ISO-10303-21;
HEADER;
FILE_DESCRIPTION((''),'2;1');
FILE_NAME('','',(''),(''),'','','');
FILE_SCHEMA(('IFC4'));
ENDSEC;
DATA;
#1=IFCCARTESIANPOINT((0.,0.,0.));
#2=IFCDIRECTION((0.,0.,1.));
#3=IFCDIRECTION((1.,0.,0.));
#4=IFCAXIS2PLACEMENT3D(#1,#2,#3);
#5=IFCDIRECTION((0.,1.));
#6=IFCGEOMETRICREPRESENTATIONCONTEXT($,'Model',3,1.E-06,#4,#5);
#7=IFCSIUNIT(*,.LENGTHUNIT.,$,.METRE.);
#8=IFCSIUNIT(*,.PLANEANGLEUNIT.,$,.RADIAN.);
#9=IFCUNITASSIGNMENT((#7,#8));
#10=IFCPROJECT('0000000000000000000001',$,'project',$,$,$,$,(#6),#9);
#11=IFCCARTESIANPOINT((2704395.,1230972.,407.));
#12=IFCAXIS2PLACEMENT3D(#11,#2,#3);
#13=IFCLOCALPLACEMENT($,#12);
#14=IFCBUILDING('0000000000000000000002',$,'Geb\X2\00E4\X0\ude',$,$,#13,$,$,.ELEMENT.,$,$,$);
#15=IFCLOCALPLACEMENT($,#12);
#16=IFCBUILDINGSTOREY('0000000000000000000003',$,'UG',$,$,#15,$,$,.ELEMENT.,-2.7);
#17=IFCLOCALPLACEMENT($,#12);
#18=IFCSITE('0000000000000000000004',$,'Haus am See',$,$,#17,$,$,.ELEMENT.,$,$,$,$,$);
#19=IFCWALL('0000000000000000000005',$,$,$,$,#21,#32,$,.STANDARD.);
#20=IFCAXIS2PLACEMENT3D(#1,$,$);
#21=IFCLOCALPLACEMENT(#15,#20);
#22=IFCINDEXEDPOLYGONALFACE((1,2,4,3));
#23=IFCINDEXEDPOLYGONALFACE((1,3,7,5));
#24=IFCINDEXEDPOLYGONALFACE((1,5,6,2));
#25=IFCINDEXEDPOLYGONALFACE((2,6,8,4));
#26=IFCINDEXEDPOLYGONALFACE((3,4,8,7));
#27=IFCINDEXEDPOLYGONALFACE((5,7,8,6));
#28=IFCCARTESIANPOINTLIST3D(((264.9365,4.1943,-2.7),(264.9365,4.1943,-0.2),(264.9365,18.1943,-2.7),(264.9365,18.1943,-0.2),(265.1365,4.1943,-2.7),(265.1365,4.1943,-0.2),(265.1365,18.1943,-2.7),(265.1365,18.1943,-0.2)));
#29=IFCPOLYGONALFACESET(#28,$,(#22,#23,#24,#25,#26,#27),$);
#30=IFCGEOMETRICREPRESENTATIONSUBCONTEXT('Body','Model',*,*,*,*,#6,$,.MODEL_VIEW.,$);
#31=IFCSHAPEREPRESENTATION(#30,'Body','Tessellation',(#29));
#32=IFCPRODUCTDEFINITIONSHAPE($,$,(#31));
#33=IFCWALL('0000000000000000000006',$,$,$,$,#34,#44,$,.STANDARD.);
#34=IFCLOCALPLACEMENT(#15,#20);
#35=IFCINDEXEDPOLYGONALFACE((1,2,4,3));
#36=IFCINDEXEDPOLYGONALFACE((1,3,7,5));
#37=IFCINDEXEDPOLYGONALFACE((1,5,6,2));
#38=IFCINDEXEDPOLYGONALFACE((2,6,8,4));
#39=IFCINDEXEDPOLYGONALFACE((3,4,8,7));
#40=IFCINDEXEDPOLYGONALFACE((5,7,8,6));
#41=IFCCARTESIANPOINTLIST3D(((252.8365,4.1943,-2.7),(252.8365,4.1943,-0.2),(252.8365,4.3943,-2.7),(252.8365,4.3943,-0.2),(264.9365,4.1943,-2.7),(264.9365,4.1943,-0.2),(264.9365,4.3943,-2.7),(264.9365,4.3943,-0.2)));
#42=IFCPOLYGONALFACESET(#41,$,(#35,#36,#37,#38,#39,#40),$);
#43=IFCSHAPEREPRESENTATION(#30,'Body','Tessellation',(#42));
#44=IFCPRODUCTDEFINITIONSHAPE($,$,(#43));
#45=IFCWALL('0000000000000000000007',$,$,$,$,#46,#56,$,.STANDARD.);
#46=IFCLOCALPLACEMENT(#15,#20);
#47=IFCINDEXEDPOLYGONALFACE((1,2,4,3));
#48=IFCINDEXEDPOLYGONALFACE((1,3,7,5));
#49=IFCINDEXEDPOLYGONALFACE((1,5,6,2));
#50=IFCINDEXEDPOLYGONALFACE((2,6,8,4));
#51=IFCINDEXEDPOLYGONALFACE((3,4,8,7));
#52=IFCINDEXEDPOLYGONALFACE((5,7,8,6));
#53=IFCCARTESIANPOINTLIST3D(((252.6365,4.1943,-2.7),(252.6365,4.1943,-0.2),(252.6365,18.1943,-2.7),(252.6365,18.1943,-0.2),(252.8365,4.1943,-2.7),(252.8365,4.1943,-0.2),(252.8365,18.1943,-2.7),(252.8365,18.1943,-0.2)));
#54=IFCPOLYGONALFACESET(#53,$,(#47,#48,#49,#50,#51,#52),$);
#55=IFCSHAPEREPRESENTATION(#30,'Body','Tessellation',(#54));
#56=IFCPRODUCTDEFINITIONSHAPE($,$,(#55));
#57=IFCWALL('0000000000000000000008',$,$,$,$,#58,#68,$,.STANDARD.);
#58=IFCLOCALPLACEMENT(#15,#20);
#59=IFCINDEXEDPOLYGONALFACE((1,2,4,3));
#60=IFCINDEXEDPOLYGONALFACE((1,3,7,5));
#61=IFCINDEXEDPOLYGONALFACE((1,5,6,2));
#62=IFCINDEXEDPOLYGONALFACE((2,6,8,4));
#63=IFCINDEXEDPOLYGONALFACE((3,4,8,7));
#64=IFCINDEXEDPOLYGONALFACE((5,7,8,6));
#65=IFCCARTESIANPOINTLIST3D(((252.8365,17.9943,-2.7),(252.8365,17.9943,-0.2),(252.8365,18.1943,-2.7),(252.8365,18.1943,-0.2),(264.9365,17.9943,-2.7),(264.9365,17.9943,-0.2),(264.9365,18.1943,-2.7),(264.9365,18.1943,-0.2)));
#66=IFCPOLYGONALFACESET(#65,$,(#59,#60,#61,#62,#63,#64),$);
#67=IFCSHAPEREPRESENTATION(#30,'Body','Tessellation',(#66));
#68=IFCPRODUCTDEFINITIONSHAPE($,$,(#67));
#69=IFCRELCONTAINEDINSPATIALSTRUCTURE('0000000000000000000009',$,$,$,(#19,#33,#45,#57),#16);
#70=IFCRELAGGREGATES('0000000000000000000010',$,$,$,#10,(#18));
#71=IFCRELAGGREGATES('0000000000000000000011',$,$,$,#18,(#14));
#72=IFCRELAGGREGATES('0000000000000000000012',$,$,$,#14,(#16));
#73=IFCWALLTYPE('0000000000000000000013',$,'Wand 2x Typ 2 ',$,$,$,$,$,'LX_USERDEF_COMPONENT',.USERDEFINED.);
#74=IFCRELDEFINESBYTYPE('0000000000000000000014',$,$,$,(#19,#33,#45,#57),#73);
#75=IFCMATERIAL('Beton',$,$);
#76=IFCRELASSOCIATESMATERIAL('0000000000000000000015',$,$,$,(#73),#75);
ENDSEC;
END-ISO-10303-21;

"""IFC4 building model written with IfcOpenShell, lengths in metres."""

from ifc_helpers import new_model, si_unit, direction, frame, origin_with_axes, place, context, subcontext, project, spatial, polyline, outline, extrude, material, type_object, element, save


model = new_model("IFC4")

# Units and contexts
model_context = context("Model", 3, precision=1e-06, world=origin_with_axes(), true_north=direction((0.0, 1.0)))
body_context = subcontext(model_context, "Body", "Model", "MODEL_VIEW")
ifc_project = project(units=[si_unit("LENGTHUNIT", "METRE"), si_unit("PLANEANGLEUNIT", "RADIAN")], contexts=[model_context])

# Site, building, storey
site_placement = place(None, frame((2704395.0, 1230972.0, 407.0), z_axis=(0.0, 0.0, 1.0), x_axis=(1.0, 0.0, 0.0)))
site = spatial("IfcSite", under=ifc_project, at=site_placement, Name="Haus am See", CompositionType="ELEMENT")
building_placement = place(None, frame((2704395.0, 1230972.0, 407.0), z_axis=(0.0, 0.0, 1.0), x_axis=(1.0, 0.0, 0.0)))
building = spatial("IfcBuilding", under=site, at=building_placement, Name="Gebäude", CompositionType="ELEMENT")
storey_placement = place(None, frame((2704395.0, 1230972.0, 407.0), z_axis=(0.0, 0.0, 1.0), x_axis=(1.0, 0.0, 0.0)))
storey = spatial("IfcBuildingStorey", under=building, at=storey_placement, Name="UG", CompositionType="ELEMENT", Elevation=-2.7)

# Walls
ifc_material_1 = material(Name="Beton")
wall_type = type_object("IfcWallType", Name="Wand 2x Typ 2 ", ElementType="LX_USERDEF_COMPONENT", PredefinedType="USERDEFINED", material=ifc_material_1)
wall_1_placement = place(storey_placement, frame((265.1365, 4.1943, -2.7), z_axis=(0.0, 0.0, 1.0), x_axis=(0.0, 1.0, 0.0)))
element("IfcWall", 1, at=wall_1_placement, inside=storey, type_object=wall_type, PredefinedType="STANDARD", context=body_context, shape_type="SweptSolid", body=[
    extrude(outline(polyline([(0.0, 0.0, 0.0), (14.0, 0.0, 0.0), (14.0, 0.2, 0.0), (0.0, 0.2, 0.0), (0.0, 0.0, 0.0)])), origin_with_axes(), (0.0, 0.0, 1.0), 2.5),
])
wall_2_placement = place(storey_placement, frame((252.8365, 4.1943, -2.7), z_axis=(0.0, 0.0, 1.0), x_axis=(1.0, 0.0, 0.0)))
element("IfcWall", 2, at=wall_2_placement, inside=storey, type_object=wall_type, PredefinedType="STANDARD", context=body_context, shape_type="SweptSolid", body=[
    extrude(outline(polyline([(0.0, 0.0, 0.0), (12.1, 0.0, 0.0), (12.1, 0.2, 0.0), (0.0, 0.2, 0.0), (0.0, 0.0, 0.0)])), origin_with_axes(), (0.0, 0.0, 1.0), 2.5),
])
wall_3_placement = place(storey_placement, frame((252.6365, 18.1943, -2.7), z_axis=(0.0, 0.0, 1.0), x_axis=(0.0, -1.0, 0.0)))
element("IfcWall", 3, at=wall_3_placement, inside=storey, type_object=wall_type, PredefinedType="STANDARD", context=body_context, shape_type="SweptSolid", body=[
    extrude(outline(polyline([(0.0, 0.0, 0.0), (14.0, 0.0, 0.0), (14.0, 0.2, 0.0), (0.0, 0.2, 0.0), (0.0, 0.0, 0.0)])), origin_with_axes(), (0.0, 0.0, 1.0), 2.5),
])
wall_4_placement = place(storey_placement, frame((264.9365, 18.1943, -2.7), z_axis=(0.0, 0.0, 1.0), x_axis=(-1.0, 0.0, 0.0)))
element("IfcWall", 4, at=wall_4_placement, inside=storey, type_object=wall_type, PredefinedType="STANDARD", context=body_context, shape_type="SweptSolid", body=[
    extrude(outline(polyline([(0.0, 0.0, 0.0), (12.1, 0.0, 0.0), (12.1, 0.2, 0.0), (0.0, 0.2, 0.0), (0.0, 0.0, 0.0)])), origin_with_axes(), (0.0, 0.0, 1.0), 2.5),
])

save(model, "model.ifc")
